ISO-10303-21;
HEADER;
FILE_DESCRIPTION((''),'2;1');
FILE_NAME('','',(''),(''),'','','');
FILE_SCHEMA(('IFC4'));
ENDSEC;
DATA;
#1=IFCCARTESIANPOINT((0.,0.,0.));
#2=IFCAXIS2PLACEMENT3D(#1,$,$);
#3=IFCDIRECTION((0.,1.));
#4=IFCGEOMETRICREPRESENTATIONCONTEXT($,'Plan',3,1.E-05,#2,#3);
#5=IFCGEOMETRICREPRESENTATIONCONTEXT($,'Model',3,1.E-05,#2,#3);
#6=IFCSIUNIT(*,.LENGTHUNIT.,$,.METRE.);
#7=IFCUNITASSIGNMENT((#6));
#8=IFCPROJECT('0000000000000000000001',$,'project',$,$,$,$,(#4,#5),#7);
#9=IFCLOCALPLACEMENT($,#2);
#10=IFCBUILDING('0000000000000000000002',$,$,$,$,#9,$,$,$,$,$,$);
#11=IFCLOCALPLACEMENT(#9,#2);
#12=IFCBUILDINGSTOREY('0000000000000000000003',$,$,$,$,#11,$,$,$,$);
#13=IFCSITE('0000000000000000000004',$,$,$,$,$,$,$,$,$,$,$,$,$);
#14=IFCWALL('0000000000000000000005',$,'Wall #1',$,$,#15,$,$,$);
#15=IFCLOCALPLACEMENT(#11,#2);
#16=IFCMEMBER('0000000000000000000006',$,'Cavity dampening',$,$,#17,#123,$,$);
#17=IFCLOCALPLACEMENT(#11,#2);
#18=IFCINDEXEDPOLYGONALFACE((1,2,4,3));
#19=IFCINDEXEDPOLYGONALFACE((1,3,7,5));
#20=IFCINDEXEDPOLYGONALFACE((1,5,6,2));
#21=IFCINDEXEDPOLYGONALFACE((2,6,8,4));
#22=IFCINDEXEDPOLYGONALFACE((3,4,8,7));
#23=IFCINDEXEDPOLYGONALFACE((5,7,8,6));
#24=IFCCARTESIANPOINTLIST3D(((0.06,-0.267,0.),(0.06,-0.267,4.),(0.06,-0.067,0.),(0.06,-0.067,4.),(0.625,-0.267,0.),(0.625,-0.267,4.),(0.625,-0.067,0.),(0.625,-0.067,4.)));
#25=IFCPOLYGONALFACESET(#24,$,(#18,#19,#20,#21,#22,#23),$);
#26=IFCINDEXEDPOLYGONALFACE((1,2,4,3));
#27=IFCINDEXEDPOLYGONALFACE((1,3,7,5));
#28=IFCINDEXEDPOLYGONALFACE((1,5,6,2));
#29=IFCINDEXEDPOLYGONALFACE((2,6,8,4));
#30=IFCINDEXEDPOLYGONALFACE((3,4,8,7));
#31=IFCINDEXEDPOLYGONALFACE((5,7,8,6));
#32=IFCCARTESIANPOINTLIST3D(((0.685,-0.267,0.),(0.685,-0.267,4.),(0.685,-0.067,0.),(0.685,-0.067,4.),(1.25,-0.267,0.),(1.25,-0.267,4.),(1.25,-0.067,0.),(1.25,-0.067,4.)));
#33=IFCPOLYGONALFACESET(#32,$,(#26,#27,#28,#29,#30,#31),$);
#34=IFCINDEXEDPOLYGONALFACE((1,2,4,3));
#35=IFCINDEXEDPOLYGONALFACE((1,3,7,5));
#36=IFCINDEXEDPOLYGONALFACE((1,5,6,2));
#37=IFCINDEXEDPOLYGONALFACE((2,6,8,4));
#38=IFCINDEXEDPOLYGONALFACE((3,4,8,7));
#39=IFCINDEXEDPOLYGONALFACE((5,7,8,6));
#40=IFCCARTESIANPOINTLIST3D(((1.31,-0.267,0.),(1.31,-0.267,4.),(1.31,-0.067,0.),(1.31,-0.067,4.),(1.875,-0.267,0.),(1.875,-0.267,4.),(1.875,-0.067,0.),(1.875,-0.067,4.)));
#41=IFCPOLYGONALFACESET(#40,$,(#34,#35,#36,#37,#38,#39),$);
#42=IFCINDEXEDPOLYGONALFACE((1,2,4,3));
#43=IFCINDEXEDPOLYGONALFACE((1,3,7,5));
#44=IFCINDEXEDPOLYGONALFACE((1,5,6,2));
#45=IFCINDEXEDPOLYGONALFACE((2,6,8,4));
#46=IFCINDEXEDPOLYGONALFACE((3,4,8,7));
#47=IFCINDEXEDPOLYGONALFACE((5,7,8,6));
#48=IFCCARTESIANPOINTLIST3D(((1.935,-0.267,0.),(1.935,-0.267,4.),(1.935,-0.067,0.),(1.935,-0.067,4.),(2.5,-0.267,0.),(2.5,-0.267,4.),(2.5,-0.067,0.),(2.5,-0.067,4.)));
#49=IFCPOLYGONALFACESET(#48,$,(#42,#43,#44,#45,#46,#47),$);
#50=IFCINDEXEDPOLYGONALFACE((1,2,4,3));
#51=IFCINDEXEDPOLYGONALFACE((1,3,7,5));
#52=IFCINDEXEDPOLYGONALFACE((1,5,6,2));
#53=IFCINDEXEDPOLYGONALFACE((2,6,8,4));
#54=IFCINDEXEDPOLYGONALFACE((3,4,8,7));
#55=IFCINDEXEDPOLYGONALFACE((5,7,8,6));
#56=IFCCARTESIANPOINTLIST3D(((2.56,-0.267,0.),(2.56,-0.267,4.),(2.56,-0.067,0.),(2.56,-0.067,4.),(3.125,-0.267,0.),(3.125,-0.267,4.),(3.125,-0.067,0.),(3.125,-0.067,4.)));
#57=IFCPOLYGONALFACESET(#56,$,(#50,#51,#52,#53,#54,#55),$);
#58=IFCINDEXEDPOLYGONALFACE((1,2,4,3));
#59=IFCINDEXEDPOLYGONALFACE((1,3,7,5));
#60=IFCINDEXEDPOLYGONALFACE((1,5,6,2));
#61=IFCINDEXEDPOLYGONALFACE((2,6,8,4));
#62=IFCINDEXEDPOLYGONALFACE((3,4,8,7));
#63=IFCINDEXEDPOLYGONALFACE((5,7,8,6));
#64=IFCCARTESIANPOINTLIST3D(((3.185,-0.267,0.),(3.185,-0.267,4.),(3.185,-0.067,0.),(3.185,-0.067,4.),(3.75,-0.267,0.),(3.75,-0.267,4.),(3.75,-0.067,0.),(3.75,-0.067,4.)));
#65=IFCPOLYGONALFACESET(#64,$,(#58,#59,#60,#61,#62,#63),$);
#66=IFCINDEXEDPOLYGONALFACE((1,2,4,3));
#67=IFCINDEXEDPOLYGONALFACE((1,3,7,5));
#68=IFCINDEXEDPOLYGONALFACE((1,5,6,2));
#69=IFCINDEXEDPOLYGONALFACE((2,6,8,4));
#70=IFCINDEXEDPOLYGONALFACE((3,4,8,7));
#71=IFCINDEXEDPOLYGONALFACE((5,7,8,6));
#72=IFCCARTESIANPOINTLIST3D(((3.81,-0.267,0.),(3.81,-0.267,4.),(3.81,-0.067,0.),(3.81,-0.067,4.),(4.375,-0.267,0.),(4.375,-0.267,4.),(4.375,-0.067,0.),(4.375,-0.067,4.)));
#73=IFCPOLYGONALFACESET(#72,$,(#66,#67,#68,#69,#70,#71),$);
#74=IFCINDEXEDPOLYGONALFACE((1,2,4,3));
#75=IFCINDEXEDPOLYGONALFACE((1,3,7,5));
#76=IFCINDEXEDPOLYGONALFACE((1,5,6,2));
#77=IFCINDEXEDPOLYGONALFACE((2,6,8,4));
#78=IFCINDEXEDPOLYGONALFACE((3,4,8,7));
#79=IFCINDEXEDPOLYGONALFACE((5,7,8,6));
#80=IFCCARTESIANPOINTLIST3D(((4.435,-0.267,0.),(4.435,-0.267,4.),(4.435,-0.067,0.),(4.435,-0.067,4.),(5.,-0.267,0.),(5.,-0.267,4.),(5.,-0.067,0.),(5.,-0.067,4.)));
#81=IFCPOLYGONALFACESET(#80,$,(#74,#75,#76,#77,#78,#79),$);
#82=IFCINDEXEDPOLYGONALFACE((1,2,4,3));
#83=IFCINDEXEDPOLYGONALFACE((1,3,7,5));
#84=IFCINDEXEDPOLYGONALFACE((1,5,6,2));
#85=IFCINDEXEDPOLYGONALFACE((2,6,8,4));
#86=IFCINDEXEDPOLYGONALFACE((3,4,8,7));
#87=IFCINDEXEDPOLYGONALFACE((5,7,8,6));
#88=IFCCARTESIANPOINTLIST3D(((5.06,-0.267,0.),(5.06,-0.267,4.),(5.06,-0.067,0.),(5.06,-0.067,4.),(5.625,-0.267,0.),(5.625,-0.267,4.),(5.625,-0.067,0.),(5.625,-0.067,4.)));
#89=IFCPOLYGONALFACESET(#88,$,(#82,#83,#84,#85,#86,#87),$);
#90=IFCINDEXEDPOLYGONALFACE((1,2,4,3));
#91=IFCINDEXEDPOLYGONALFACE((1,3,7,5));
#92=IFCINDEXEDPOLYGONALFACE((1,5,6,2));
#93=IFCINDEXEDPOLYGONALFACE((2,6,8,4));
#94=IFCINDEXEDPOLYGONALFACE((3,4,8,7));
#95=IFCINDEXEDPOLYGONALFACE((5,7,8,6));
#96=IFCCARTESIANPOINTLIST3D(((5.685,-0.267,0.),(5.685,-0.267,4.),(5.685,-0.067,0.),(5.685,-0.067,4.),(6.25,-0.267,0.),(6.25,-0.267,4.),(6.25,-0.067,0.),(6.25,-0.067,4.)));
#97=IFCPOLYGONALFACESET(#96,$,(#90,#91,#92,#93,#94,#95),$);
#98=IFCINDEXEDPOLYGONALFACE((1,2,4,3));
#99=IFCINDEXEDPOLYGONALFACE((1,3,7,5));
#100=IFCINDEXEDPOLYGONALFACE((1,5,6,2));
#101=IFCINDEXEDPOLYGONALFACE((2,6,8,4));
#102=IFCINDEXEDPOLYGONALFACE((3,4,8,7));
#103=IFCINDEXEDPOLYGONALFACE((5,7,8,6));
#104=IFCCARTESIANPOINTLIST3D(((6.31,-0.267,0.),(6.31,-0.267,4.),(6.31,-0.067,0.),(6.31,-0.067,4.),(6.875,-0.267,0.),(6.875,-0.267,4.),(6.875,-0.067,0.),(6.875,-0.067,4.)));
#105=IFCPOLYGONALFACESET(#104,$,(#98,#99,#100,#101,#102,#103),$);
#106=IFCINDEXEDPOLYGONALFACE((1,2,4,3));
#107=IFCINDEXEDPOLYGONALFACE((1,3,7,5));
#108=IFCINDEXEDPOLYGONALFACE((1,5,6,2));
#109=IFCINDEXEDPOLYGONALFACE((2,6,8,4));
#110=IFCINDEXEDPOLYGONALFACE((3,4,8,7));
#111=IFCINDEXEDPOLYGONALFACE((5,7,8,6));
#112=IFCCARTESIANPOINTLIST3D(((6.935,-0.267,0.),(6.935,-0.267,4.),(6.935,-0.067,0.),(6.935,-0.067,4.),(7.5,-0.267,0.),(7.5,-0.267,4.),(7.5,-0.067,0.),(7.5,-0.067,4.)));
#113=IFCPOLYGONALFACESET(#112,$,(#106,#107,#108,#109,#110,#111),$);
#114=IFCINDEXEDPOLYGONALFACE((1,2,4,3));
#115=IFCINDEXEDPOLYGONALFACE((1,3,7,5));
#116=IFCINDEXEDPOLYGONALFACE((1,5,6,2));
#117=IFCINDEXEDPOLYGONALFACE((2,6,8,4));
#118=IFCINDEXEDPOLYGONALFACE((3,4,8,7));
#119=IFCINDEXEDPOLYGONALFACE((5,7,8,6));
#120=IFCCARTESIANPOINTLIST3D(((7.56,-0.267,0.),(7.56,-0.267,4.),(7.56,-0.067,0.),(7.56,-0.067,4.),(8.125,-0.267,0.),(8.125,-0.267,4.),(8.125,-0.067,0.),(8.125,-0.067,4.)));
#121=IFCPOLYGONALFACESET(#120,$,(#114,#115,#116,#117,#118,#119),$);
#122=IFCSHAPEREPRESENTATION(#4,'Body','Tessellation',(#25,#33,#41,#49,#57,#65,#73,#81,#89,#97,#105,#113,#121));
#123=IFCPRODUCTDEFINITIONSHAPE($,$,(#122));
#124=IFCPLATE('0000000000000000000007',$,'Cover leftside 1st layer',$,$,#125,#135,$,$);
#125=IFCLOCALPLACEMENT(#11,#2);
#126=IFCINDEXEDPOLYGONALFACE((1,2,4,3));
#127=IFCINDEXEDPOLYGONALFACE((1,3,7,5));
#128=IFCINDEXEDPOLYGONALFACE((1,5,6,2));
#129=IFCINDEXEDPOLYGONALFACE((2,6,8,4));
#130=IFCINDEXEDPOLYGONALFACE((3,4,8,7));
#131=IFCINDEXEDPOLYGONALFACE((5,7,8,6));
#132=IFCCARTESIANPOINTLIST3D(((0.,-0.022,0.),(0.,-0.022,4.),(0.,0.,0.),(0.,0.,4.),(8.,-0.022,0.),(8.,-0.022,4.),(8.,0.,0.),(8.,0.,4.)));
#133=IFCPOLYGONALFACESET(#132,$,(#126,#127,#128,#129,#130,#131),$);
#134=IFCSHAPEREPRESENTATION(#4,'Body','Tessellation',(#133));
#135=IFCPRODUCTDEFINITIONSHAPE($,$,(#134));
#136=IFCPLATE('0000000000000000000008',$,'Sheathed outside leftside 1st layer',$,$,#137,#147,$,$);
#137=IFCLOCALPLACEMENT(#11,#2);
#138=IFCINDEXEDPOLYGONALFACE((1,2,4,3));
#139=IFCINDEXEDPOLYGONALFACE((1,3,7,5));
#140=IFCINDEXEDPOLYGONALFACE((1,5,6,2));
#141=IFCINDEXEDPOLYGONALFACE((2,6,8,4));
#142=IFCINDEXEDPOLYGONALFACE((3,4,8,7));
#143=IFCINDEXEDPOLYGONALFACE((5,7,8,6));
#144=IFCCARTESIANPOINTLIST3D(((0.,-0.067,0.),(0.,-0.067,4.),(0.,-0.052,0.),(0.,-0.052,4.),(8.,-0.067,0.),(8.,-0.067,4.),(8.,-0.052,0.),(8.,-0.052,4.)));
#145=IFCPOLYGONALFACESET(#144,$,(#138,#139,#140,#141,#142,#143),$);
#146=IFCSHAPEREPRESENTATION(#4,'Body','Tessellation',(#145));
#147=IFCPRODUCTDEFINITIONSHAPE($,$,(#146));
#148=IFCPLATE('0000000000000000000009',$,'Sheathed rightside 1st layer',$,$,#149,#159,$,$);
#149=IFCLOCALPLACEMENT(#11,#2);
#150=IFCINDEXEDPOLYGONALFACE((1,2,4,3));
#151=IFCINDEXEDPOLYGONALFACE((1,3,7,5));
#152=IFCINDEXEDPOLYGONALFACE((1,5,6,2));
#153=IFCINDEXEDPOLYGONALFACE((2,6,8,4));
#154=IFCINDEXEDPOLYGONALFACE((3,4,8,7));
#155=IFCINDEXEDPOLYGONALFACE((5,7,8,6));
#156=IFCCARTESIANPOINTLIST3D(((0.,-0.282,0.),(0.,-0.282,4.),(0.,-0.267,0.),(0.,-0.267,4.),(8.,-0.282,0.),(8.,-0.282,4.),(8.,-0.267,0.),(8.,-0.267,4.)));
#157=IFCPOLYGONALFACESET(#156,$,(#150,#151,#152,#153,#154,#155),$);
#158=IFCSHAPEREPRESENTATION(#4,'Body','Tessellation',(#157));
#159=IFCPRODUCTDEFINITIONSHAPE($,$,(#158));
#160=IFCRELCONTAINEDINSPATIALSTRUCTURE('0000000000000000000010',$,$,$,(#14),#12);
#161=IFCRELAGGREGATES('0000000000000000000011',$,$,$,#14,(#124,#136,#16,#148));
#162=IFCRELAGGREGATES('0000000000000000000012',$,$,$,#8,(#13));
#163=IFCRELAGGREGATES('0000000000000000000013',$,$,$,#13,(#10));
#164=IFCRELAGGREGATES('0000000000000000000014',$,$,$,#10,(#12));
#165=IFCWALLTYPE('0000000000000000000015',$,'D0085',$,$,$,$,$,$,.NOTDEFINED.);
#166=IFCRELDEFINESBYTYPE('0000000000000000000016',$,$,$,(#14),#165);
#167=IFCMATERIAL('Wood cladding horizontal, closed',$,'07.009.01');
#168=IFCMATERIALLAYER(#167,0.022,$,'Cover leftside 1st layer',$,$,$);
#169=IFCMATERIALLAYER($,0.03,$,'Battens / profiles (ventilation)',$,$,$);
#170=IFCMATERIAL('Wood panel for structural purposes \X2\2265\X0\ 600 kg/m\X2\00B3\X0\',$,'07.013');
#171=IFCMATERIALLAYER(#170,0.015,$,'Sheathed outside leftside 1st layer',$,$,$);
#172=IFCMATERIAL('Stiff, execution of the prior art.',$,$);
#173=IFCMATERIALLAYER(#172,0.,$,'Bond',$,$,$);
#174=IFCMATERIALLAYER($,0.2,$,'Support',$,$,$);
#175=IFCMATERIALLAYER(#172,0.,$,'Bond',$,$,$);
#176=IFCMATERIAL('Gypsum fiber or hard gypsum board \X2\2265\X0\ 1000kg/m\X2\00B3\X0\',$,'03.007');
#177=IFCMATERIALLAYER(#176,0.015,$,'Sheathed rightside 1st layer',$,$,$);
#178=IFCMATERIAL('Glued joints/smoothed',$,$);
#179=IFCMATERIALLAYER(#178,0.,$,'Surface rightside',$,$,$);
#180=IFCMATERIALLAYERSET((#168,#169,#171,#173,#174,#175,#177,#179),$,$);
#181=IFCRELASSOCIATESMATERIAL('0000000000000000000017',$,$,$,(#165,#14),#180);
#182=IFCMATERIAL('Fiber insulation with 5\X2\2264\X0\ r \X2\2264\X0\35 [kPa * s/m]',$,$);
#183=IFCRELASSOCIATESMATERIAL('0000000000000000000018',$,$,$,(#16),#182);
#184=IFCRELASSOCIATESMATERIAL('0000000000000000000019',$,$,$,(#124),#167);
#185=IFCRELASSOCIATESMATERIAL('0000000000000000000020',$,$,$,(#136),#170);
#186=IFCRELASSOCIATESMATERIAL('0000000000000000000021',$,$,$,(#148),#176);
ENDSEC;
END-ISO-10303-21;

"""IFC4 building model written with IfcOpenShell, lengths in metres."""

from ifc_helpers import new_model, si_unit, direction, frame, frame_2d, origin, origin_with_axes, place, context, project, spatial, rectangle, extrude, material, layer, layer_set, type_object, element, aggregate, save


model = new_model("IFC4")

# Units and contexts
plan_context = context("Plan", 3, precision=1e-05, world=origin(), true_north=direction((0.0, 1.0)))
model_context = context("Model", 3, precision=1e-05, world=origin(), true_north=direction((0.0, 1.0)))
ifc_project = project(units=[si_unit("LENGTHUNIT", "METRE")], contexts=[plan_context, model_context])

# Site, building, storey
site = spatial("IfcSite", under=ifc_project)
building_placement = place(None, origin())
building = spatial("IfcBuilding", under=site, at=building_placement)
storey_placement = place(building_placement, origin())
storey = spatial("IfcBuildingStorey", under=building, at=storey_placement)

# Wall, member, plates
ifc_material_1 = material(Name="Wood cladding horizontal, closed", Category="07.009.01")
ifc_layer_1 = layer(ifc_material_1, 0.022, Name="Cover leftside 1st layer")
ifc_layer_2 = layer(None, 0.03, Name="Battens / profiles (ventilation)")
ifc_material_2 = material(Name="Wood panel for structural purposes ≥ 600 kg/m³", Category="07.013")
ifc_layer_3 = layer(ifc_material_2, 0.015, Name="Sheathed outside leftside 1st layer")
ifc_material_3 = material(Name="Stiff, execution of the prior art.")
ifc_layer_4 = layer(ifc_material_3, 0.0, Name="Bond")
ifc_layer_5 = layer(None, 0.2, Name="Support")
ifc_layer_6 = layer(ifc_material_3, 0.0, Name="Bond")
ifc_material_4 = material(Name="Gypsum fiber or hard gypsum board ≥ 1000kg/m³", Category="03.007")
ifc_layer_7 = layer(ifc_material_4, 0.015, Name="Sheathed rightside 1st layer")
ifc_material_5 = material(Name="Glued joints/smoothed")
ifc_layer_8 = layer(ifc_material_5, 0.0, Name="Surface rightside")
ifc_layer_set = layer_set([ifc_layer_1, ifc_layer_2, ifc_layer_3, ifc_layer_4, ifc_layer_5, ifc_layer_6, ifc_layer_7, ifc_layer_8])
wall_type = type_object("IfcWallType", Name="D0085", PredefinedType="NOTDEFINED", material=ifc_layer_set)
wall_placement = place(None, frame((0.0, 0.0, 0.0), z_axis=(0.0, -1.0, 0.0), x_axis=(1.0, 0.0, 0.0)))
wall = element("IfcWall", 1, at=wall_placement, inside=storey, type_object=wall_type, material=ifc_layer_set, Name="Wall #1")
ifc_material_6 = material(Name="Fiber insulation with 5≤ r ≤35 [kPa * s/m]")
member_1_placement = place(wall_placement, origin())
member_1 = element("IfcMember", 2, at=member_1_placement, material=ifc_material_6, Name="Cavity dampening", context=plan_context, shape_type="SweptSolid", body=[
    extrude(rectangle(XDim=0.565, YDim=0.2, at=frame_2d((0.2825, 0.1), x_axis=(1.0, 0.0))), frame((0.06, 4.0, 0.067), z_axis=(0.0, -1.0, 0.0), x_axis=(1.0, 0.0, 0.0)), (0.0, 0.0, 1.0), 4.0),
    extrude(rectangle(XDim=0.565, YDim=0.2, at=frame_2d((0.2825, 0.1), x_axis=(1.0, 0.0))), frame((0.685, 4.0, 0.067), z_axis=(0.0, -1.0, 0.0), x_axis=(1.0, 0.0, 0.0)), (0.0, 0.0, 1.0), 4.0),
    extrude(rectangle(XDim=0.565, YDim=0.2, at=frame_2d((0.2825, 0.1), x_axis=(1.0, 0.0))), frame((1.31, 4.0, 0.067), z_axis=(0.0, -1.0, 0.0), x_axis=(1.0, 0.0, 0.0)), (0.0, 0.0, 1.0), 4.0),
    extrude(rectangle(XDim=0.565, YDim=0.2, at=frame_2d((0.2825, 0.1), x_axis=(1.0, 0.0))), frame((1.935, 4.0, 0.067), z_axis=(0.0, -1.0, 0.0), x_axis=(1.0, 0.0, 0.0)), (0.0, 0.0, 1.0), 4.0),
    extrude(rectangle(XDim=0.565, YDim=0.2, at=frame_2d((0.2825, 0.1), x_axis=(1.0, 0.0))), frame((2.56, 4.0, 0.067), z_axis=(0.0, -1.0, 0.0), x_axis=(1.0, 0.0, 0.0)), (0.0, 0.0, 1.0), 4.0),
    extrude(rectangle(XDim=0.565, YDim=0.2, at=frame_2d((0.2825, 0.1), x_axis=(1.0, 0.0))), frame((3.185, 4.0, 0.067), z_axis=(0.0, -1.0, 0.0), x_axis=(1.0, 0.0, 0.0)), (0.0, 0.0, 1.0), 4.0),
    extrude(rectangle(XDim=0.565, YDim=0.2, at=frame_2d((0.2825, 0.1), x_axis=(1.0, 0.0))), frame((3.81, 4.0, 0.067), z_axis=(0.0, -1.0, 0.0), x_axis=(1.0, 0.0, 0.0)), (0.0, 0.0, 1.0), 4.0),
    extrude(rectangle(XDim=0.565, YDim=0.2, at=frame_2d((0.2825, 0.1), x_axis=(1.0, 0.0))), frame((4.435, 4.0, 0.067), z_axis=(0.0, -1.0, 0.0), x_axis=(1.0, 0.0, 0.0)), (0.0, 0.0, 1.0), 4.0),
    extrude(rectangle(XDim=0.565, YDim=0.2, at=frame_2d((0.2825, 0.1), x_axis=(1.0, 0.0))), frame((5.06, 4.0, 0.067), z_axis=(0.0, -1.0, 0.0), x_axis=(1.0, 0.0, 0.0)), (0.0, 0.0, 1.0), 4.0),
    extrude(rectangle(XDim=0.565, YDim=0.2, at=frame_2d((0.2825, 0.1), x_axis=(1.0, 0.0))), frame((5.685, 4.0, 0.067), z_axis=(0.0, -1.0, 0.0), x_axis=(1.0, 0.0, 0.0)), (0.0, 0.0, 1.0), 4.0),
    extrude(rectangle(XDim=0.565, YDim=0.2, at=frame_2d((0.2825, 0.1), x_axis=(1.0, 0.0))), frame((6.31, 4.0, 0.067), z_axis=(0.0, -1.0, 0.0), x_axis=(1.0, 0.0, 0.0)), (0.0, 0.0, 1.0), 4.0),
    extrude(rectangle(XDim=0.565, YDim=0.2, at=frame_2d((0.2825, 0.1), x_axis=(1.0, 0.0))), frame((6.935, 4.0, 0.067), z_axis=(0.0, -1.0, 0.0), x_axis=(1.0, 0.0, 0.0)), (0.0, 0.0, 1.0), 4.0),
    extrude(rectangle(XDim=0.565, YDim=0.2, at=frame_2d((0.2825, 0.1), x_axis=(1.0, 0.0))), frame((7.56, 4.0, 0.067), z_axis=(0.0, -1.0, 0.0), x_axis=(1.0, 0.0, 0.0)), (0.0, 0.0, 1.0), 4.0),
])
plate_1_placement = place(wall_placement, origin())
plate_1 = element("IfcPlate", 3, at=plate_1_placement, material=ifc_material_1, Name="Cover leftside 1st layer", context=plan_context, shape_type="SweptSolid", body=[
    extrude(rectangle(XDim=8.0, YDim=4.0, at=frame_2d((4.0, 2.0), x_axis=(1.0, 0.0))), origin_with_axes(), (0.0, 0.0, 1.0), 0.022),
])
plate_2_placement = place(wall_placement, origin())
plate_2 = element("IfcPlate", 4, at=plate_2_placement, material=ifc_material_2, Name="Sheathed outside leftside 1st layer", context=plan_context, shape_type="SweptSolid", body=[
    extrude(rectangle(XDim=8.0, YDim=4.0, at=frame_2d((4.0, 2.0), x_axis=(1.0, 0.0))), frame((0.0, 0.0, 0.052), z_axis=(0.0, 0.0, 1.0), x_axis=(1.0, 0.0, 0.0)), (0.0, 0.0, 1.0), 0.015),
])
plate_3_placement = place(wall_placement, origin())
plate_3 = element("IfcPlate", 5, at=plate_3_placement, material=ifc_material_4, Name="Sheathed rightside 1st layer", context=plan_context, shape_type="SweptSolid", body=[
    extrude(rectangle(XDim=8.0, YDim=4.0, at=frame_2d((4.0, 2.0), x_axis=(1.0, 0.0))), frame((0.0, 0.0, 0.267), z_axis=(0.0, 0.0, 1.0), x_axis=(1.0, 0.0, 0.0)), (0.0, 0.0, 1.0), 0.015),
])
aggregate(wall, [plate_1, plate_2, member_1, plate_3])

save(model, "model.ifc")
